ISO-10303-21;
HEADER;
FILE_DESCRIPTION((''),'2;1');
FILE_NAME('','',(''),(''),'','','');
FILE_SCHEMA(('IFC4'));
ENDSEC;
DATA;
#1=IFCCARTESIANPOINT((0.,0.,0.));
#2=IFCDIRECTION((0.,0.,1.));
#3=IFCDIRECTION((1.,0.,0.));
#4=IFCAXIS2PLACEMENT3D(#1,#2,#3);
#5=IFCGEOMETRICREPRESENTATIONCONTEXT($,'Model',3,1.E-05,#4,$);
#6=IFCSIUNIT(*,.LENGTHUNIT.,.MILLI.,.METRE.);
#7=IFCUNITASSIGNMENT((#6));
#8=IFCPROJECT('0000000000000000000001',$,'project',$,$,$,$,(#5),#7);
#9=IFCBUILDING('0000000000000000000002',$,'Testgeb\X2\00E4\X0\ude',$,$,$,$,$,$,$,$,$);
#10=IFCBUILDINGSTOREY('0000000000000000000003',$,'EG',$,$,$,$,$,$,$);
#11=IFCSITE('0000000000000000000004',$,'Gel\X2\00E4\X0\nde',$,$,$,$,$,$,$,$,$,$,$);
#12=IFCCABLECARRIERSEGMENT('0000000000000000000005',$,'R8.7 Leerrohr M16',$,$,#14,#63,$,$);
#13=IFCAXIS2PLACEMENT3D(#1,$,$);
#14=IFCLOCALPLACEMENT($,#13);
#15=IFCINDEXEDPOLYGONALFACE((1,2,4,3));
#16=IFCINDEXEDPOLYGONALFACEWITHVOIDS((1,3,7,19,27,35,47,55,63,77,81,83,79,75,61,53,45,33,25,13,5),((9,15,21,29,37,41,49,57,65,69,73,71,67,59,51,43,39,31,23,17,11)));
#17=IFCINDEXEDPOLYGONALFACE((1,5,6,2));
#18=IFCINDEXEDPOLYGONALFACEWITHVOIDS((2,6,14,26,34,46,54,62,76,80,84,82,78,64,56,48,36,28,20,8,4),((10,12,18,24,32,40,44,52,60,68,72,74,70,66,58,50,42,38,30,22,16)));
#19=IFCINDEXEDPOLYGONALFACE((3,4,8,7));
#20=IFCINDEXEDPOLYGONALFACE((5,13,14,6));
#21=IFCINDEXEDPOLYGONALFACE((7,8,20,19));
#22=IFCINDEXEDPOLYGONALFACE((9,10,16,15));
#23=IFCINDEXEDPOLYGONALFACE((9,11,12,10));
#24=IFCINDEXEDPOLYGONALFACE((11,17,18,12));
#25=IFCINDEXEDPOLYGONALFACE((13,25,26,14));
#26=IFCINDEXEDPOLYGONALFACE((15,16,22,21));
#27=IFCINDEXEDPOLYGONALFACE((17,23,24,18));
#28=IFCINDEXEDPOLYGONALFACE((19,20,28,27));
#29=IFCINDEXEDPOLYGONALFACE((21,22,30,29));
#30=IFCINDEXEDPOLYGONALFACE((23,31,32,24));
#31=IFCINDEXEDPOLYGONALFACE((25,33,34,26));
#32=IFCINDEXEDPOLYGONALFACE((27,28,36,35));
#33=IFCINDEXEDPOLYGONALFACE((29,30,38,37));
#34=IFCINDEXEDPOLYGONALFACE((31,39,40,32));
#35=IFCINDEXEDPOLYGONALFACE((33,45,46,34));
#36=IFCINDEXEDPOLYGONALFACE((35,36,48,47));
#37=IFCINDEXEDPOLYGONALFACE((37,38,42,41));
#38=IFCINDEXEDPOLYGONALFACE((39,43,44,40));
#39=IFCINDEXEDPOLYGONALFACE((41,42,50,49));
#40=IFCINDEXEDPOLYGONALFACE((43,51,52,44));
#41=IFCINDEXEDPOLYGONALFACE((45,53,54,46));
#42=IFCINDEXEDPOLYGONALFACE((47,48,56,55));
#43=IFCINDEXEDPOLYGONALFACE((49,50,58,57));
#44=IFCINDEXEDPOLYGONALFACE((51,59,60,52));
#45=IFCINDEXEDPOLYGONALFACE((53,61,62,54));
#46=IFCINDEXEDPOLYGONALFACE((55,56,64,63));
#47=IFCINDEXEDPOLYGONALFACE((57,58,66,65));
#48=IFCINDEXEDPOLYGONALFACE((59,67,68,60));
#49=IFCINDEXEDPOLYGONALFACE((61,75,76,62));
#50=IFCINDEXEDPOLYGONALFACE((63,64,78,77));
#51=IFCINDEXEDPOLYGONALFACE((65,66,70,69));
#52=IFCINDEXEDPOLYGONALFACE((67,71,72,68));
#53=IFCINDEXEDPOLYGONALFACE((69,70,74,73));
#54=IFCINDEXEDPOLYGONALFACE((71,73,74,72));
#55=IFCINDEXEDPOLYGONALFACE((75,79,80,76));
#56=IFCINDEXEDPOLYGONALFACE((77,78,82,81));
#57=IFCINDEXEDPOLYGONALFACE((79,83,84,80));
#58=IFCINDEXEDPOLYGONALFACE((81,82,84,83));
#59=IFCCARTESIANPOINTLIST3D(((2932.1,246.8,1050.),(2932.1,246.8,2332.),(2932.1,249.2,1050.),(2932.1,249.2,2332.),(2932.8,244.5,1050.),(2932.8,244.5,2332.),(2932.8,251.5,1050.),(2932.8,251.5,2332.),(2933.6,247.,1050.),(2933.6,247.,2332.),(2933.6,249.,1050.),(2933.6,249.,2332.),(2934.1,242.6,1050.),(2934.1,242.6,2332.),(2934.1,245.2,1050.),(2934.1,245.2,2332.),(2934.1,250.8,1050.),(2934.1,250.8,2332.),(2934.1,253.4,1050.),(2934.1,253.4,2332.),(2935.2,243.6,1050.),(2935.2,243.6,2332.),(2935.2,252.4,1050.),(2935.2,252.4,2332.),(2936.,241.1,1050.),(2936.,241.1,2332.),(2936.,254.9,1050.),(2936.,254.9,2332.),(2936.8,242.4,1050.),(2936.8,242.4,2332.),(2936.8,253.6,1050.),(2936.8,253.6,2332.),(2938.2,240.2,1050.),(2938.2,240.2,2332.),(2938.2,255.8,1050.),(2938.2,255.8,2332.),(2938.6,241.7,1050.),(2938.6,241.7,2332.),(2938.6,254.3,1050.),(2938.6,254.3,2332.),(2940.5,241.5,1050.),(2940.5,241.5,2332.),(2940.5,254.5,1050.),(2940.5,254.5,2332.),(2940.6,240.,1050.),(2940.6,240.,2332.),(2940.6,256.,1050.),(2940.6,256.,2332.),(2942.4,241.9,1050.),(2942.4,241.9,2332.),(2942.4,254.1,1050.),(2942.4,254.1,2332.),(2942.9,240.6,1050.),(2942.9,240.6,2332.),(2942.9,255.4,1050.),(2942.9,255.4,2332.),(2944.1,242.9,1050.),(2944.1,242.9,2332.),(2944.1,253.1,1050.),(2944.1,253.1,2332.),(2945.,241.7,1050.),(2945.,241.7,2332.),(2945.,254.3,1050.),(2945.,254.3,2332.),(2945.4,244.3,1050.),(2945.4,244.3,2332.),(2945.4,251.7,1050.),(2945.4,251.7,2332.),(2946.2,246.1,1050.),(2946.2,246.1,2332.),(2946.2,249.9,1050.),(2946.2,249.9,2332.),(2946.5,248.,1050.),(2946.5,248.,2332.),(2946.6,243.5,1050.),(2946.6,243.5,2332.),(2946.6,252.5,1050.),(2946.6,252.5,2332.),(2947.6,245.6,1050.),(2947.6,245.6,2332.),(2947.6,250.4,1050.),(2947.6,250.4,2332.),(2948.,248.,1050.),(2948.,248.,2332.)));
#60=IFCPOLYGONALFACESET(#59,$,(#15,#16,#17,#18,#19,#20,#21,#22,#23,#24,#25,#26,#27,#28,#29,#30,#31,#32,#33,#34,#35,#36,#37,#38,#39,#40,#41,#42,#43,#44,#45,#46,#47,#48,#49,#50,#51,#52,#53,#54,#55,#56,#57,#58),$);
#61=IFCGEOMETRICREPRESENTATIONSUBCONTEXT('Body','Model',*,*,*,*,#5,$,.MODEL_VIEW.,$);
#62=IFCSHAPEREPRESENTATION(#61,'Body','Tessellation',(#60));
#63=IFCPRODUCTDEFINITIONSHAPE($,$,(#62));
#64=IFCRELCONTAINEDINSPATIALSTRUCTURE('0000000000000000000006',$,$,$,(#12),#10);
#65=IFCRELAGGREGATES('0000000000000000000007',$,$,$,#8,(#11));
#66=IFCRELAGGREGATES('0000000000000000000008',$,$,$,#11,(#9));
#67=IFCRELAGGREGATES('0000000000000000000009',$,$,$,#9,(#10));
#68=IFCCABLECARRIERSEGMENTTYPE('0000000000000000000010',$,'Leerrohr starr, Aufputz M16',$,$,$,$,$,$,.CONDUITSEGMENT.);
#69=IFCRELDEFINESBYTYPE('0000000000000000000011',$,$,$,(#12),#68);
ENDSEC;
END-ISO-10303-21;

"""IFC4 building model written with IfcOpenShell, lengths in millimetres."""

from ifc_helpers import new_model, si_unit, frame, origin_with_axes, place, context, subcontext, project, spatial, hollow_circle, extrude, type_object, element, save


model = new_model("IFC4")

# Units and contexts
model_context = context("Model", 3, precision=1e-05, world=origin_with_axes())
body_context = subcontext(model_context, "Body", "Model", "MODEL_VIEW")
ifc_project = project(units=[si_unit("LENGTHUNIT", "METRE", prefix="MILLI")], contexts=[model_context])

# Site, building, storey
site = spatial("IfcSite", under=ifc_project, Name="Gelände")
building = spatial("IfcBuilding", under=site, Name="Testgebäude")
storey = spatial("IfcBuildingStorey", under=building, Name="EG")

# Cable carrier segment
cable_carrier_segment_type_1 = type_object("IfcCableCarrierSegmentType", Name="Leerrohr starr, Aufputz M16", PredefinedType="CONDUITSEGMENT")
cable_carrier_segment_1_placement = place(None, frame((2940.0, 248.0, 2332.0), z_axis=(0.0, 0.0, -1.0), x_axis=(1.0, 0.0, 0.0)))
element("IfcCableCarrierSegment", 1, at=cable_carrier_segment_1_placement, inside=storey, type_object=cable_carrier_segment_type_1, Name="R8.7 Leerrohr M16", context=body_context, shape_type="SweptSolid", body=[
    extrude(hollow_circle(Radius=8.0, WallThickness=1.5), None, (0.0, 0.0, 1.0), 1282.0),
])

save(model, "model.ifc")
